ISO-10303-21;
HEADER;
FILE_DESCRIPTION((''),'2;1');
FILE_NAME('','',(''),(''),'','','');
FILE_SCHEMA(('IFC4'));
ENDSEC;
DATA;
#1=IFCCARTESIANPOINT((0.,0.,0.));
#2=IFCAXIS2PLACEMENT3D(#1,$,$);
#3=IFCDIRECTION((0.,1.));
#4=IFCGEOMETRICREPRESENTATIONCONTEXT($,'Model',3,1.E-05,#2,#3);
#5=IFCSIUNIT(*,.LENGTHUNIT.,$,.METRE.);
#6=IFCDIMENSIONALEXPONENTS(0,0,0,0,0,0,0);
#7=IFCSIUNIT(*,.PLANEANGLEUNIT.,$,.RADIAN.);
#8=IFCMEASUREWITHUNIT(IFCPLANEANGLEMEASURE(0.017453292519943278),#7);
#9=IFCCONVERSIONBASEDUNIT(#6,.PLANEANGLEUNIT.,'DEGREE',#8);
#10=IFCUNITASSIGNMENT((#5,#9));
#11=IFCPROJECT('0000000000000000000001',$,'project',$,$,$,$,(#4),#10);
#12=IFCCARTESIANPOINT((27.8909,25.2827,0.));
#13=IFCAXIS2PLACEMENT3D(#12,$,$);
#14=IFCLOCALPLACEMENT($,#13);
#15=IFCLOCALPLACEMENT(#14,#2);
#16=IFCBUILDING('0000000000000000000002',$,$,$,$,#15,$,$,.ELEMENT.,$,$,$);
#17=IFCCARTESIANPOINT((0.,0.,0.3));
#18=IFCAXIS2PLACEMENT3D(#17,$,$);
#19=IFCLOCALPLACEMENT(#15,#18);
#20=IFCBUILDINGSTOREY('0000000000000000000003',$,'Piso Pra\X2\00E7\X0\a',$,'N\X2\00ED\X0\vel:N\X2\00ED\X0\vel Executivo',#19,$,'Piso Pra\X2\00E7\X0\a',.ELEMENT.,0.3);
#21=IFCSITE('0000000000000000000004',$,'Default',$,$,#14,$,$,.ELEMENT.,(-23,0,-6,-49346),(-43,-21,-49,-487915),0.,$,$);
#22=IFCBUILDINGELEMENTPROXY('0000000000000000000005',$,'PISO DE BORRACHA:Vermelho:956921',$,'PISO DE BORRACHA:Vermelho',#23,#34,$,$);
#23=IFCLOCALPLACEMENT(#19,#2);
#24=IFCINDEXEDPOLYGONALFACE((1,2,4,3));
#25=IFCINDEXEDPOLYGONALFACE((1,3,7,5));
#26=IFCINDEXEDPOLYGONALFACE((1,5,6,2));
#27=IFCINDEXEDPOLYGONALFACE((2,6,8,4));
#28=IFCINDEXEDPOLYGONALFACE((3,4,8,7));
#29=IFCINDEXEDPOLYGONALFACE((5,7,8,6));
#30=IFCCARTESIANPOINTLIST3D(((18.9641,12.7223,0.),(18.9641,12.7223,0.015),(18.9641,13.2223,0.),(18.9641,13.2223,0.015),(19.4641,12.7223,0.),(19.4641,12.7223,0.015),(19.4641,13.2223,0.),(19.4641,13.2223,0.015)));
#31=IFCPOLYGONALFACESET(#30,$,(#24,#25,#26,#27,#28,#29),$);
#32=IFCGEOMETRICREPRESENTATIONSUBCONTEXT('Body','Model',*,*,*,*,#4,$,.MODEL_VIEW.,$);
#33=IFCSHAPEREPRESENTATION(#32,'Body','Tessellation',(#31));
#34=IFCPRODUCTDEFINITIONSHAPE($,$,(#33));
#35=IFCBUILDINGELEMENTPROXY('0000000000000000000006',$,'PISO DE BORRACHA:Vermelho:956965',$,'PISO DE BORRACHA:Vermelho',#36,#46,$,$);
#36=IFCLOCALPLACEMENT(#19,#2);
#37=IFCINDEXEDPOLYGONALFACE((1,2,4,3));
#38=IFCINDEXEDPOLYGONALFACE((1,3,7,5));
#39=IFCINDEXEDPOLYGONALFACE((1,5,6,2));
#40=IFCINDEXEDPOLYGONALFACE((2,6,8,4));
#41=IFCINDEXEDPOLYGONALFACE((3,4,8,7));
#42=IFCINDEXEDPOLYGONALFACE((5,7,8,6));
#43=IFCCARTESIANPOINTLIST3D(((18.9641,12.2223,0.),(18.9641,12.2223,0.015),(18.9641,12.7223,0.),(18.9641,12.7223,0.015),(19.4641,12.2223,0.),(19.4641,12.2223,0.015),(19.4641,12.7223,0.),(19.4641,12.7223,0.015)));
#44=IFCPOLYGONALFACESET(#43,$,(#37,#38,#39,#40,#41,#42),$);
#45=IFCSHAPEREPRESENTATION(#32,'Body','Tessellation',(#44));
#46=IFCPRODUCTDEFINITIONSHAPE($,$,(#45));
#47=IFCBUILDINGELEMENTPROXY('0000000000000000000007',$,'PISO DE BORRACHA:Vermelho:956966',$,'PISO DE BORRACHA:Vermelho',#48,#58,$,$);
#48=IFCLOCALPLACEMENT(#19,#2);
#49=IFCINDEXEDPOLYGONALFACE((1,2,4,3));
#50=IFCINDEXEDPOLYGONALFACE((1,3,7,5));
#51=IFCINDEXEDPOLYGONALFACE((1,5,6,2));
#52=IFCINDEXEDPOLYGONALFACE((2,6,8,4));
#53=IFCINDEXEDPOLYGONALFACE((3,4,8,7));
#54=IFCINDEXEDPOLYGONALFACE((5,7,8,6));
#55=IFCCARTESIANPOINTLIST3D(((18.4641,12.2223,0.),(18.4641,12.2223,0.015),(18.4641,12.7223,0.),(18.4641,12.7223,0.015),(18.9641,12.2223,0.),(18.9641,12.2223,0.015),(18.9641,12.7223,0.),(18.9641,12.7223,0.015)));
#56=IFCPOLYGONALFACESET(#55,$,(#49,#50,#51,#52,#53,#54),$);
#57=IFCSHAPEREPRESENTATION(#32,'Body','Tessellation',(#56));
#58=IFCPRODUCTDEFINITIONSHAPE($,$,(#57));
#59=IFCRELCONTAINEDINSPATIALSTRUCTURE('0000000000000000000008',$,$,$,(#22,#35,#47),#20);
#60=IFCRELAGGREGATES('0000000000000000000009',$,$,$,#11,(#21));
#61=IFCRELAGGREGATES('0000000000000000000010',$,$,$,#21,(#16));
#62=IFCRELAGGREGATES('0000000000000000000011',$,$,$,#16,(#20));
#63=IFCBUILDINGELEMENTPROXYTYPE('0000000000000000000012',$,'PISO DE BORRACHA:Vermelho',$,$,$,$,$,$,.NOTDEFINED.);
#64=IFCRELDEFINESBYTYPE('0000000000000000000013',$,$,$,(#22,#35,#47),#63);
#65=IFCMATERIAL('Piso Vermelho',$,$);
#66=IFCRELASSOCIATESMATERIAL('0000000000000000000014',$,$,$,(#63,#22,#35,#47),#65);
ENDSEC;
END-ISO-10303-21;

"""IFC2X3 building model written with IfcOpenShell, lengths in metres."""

from ifc_helpers import new_model, entity, si_unit, converted_unit, direction, frame, origin, origin_2d_with_axis, place, context, subcontext, project, spatial, rectangle, extrude, source, transform, mapped, material, type_object, type_shapes, element, save


model = new_model("IFC2X3")

# Units and contexts
model_context = context("Model", 3, precision=1e-05, world=origin(), true_north=direction((0.0, 1.0)))
body_context = subcontext(model_context, "Body", "Model", "MODEL_VIEW")
ifc_project = project(units=[si_unit("LENGTHUNIT", "METRE"), converted_unit("PLANEANGLEUNIT", "DEGREE", entity("IfcPlaneAngleMeasure", 0.017453292519943278), si_unit("PLANEANGLEUNIT", "RADIAN"), dimensions=[0, 0, 0, 0, 0, 0, 0])], contexts=[model_context])

# Site, building, storey
site_placement = place(None, frame((27.8909, 25.2827, 0.0)))
site = spatial("IfcSite", under=ifc_project, at=site_placement, Name="Default", CompositionType="ELEMENT", RefLatitude=(-23, 0, -6, -49346), RefLongitude=(-43, -21, -49, -487915), RefElevation=0.0)
building_placement = place(site_placement, origin())
building = spatial("IfcBuilding", under=site, at=building_placement, CompositionType="ELEMENT")
storey_placement = place(building_placement, frame((0.0, 0.0, 0.3)))
storey = spatial("IfcBuildingStorey", under=building, at=storey_placement, Name="Piso Praça", ObjectType="Nível:Nível Executivo", LongName="Piso Praça", CompositionType="ELEMENT", Elevation=0.3)

# Building element proxies
ifc_material_1 = material(Name="Piso Vermelho")
building_element_proxy_type_1 = type_object("IfcBuildingElementProxyType", Name="PISO DE BORRACHA:Vermelho", PredefinedType="NOTDEFINED", material=ifc_material_1)
shared_shape_1 = source(origin(), body_context, "Body", "SweptSolid", [
    extrude(rectangle(XDim=0.5, YDim=0.5, at=origin_2d_with_axis()), frame((0.25, 0.25, 0.0), z_axis=(0.0, 0.0, 1.0), x_axis=(-1.0, 0.0, 0.0)), (0.0, 0.0, 1.0), 0.015),
])
type_shapes(building_element_proxy_type_1, [shared_shape_1])
for number, where, name in (
    (1, (18.9641, 12.7223, 0.0), "PISO DE BORRACHA:Vermelho:956921"),
    (2, (18.9641, 12.2223, 0.0), "PISO DE BORRACHA:Vermelho:956965"),
    (3, (18.4641, 12.2223, 0.0), "PISO DE BORRACHA:Vermelho:956966"),
):
    element("IfcBuildingElementProxy", number, at=place(storey_placement, frame(where)), inside=storey, type_object=building_element_proxy_type_1, material=ifc_material_1, Name=name, ObjectType="PISO DE BORRACHA:Vermelho", context=body_context, shape_type="MappedRepresentation", body=[
        mapped(shared_shape_1, transform((0.0, 0.0, 0.0), scale=1.0)),
    ])

save(model, "model.ifc")
